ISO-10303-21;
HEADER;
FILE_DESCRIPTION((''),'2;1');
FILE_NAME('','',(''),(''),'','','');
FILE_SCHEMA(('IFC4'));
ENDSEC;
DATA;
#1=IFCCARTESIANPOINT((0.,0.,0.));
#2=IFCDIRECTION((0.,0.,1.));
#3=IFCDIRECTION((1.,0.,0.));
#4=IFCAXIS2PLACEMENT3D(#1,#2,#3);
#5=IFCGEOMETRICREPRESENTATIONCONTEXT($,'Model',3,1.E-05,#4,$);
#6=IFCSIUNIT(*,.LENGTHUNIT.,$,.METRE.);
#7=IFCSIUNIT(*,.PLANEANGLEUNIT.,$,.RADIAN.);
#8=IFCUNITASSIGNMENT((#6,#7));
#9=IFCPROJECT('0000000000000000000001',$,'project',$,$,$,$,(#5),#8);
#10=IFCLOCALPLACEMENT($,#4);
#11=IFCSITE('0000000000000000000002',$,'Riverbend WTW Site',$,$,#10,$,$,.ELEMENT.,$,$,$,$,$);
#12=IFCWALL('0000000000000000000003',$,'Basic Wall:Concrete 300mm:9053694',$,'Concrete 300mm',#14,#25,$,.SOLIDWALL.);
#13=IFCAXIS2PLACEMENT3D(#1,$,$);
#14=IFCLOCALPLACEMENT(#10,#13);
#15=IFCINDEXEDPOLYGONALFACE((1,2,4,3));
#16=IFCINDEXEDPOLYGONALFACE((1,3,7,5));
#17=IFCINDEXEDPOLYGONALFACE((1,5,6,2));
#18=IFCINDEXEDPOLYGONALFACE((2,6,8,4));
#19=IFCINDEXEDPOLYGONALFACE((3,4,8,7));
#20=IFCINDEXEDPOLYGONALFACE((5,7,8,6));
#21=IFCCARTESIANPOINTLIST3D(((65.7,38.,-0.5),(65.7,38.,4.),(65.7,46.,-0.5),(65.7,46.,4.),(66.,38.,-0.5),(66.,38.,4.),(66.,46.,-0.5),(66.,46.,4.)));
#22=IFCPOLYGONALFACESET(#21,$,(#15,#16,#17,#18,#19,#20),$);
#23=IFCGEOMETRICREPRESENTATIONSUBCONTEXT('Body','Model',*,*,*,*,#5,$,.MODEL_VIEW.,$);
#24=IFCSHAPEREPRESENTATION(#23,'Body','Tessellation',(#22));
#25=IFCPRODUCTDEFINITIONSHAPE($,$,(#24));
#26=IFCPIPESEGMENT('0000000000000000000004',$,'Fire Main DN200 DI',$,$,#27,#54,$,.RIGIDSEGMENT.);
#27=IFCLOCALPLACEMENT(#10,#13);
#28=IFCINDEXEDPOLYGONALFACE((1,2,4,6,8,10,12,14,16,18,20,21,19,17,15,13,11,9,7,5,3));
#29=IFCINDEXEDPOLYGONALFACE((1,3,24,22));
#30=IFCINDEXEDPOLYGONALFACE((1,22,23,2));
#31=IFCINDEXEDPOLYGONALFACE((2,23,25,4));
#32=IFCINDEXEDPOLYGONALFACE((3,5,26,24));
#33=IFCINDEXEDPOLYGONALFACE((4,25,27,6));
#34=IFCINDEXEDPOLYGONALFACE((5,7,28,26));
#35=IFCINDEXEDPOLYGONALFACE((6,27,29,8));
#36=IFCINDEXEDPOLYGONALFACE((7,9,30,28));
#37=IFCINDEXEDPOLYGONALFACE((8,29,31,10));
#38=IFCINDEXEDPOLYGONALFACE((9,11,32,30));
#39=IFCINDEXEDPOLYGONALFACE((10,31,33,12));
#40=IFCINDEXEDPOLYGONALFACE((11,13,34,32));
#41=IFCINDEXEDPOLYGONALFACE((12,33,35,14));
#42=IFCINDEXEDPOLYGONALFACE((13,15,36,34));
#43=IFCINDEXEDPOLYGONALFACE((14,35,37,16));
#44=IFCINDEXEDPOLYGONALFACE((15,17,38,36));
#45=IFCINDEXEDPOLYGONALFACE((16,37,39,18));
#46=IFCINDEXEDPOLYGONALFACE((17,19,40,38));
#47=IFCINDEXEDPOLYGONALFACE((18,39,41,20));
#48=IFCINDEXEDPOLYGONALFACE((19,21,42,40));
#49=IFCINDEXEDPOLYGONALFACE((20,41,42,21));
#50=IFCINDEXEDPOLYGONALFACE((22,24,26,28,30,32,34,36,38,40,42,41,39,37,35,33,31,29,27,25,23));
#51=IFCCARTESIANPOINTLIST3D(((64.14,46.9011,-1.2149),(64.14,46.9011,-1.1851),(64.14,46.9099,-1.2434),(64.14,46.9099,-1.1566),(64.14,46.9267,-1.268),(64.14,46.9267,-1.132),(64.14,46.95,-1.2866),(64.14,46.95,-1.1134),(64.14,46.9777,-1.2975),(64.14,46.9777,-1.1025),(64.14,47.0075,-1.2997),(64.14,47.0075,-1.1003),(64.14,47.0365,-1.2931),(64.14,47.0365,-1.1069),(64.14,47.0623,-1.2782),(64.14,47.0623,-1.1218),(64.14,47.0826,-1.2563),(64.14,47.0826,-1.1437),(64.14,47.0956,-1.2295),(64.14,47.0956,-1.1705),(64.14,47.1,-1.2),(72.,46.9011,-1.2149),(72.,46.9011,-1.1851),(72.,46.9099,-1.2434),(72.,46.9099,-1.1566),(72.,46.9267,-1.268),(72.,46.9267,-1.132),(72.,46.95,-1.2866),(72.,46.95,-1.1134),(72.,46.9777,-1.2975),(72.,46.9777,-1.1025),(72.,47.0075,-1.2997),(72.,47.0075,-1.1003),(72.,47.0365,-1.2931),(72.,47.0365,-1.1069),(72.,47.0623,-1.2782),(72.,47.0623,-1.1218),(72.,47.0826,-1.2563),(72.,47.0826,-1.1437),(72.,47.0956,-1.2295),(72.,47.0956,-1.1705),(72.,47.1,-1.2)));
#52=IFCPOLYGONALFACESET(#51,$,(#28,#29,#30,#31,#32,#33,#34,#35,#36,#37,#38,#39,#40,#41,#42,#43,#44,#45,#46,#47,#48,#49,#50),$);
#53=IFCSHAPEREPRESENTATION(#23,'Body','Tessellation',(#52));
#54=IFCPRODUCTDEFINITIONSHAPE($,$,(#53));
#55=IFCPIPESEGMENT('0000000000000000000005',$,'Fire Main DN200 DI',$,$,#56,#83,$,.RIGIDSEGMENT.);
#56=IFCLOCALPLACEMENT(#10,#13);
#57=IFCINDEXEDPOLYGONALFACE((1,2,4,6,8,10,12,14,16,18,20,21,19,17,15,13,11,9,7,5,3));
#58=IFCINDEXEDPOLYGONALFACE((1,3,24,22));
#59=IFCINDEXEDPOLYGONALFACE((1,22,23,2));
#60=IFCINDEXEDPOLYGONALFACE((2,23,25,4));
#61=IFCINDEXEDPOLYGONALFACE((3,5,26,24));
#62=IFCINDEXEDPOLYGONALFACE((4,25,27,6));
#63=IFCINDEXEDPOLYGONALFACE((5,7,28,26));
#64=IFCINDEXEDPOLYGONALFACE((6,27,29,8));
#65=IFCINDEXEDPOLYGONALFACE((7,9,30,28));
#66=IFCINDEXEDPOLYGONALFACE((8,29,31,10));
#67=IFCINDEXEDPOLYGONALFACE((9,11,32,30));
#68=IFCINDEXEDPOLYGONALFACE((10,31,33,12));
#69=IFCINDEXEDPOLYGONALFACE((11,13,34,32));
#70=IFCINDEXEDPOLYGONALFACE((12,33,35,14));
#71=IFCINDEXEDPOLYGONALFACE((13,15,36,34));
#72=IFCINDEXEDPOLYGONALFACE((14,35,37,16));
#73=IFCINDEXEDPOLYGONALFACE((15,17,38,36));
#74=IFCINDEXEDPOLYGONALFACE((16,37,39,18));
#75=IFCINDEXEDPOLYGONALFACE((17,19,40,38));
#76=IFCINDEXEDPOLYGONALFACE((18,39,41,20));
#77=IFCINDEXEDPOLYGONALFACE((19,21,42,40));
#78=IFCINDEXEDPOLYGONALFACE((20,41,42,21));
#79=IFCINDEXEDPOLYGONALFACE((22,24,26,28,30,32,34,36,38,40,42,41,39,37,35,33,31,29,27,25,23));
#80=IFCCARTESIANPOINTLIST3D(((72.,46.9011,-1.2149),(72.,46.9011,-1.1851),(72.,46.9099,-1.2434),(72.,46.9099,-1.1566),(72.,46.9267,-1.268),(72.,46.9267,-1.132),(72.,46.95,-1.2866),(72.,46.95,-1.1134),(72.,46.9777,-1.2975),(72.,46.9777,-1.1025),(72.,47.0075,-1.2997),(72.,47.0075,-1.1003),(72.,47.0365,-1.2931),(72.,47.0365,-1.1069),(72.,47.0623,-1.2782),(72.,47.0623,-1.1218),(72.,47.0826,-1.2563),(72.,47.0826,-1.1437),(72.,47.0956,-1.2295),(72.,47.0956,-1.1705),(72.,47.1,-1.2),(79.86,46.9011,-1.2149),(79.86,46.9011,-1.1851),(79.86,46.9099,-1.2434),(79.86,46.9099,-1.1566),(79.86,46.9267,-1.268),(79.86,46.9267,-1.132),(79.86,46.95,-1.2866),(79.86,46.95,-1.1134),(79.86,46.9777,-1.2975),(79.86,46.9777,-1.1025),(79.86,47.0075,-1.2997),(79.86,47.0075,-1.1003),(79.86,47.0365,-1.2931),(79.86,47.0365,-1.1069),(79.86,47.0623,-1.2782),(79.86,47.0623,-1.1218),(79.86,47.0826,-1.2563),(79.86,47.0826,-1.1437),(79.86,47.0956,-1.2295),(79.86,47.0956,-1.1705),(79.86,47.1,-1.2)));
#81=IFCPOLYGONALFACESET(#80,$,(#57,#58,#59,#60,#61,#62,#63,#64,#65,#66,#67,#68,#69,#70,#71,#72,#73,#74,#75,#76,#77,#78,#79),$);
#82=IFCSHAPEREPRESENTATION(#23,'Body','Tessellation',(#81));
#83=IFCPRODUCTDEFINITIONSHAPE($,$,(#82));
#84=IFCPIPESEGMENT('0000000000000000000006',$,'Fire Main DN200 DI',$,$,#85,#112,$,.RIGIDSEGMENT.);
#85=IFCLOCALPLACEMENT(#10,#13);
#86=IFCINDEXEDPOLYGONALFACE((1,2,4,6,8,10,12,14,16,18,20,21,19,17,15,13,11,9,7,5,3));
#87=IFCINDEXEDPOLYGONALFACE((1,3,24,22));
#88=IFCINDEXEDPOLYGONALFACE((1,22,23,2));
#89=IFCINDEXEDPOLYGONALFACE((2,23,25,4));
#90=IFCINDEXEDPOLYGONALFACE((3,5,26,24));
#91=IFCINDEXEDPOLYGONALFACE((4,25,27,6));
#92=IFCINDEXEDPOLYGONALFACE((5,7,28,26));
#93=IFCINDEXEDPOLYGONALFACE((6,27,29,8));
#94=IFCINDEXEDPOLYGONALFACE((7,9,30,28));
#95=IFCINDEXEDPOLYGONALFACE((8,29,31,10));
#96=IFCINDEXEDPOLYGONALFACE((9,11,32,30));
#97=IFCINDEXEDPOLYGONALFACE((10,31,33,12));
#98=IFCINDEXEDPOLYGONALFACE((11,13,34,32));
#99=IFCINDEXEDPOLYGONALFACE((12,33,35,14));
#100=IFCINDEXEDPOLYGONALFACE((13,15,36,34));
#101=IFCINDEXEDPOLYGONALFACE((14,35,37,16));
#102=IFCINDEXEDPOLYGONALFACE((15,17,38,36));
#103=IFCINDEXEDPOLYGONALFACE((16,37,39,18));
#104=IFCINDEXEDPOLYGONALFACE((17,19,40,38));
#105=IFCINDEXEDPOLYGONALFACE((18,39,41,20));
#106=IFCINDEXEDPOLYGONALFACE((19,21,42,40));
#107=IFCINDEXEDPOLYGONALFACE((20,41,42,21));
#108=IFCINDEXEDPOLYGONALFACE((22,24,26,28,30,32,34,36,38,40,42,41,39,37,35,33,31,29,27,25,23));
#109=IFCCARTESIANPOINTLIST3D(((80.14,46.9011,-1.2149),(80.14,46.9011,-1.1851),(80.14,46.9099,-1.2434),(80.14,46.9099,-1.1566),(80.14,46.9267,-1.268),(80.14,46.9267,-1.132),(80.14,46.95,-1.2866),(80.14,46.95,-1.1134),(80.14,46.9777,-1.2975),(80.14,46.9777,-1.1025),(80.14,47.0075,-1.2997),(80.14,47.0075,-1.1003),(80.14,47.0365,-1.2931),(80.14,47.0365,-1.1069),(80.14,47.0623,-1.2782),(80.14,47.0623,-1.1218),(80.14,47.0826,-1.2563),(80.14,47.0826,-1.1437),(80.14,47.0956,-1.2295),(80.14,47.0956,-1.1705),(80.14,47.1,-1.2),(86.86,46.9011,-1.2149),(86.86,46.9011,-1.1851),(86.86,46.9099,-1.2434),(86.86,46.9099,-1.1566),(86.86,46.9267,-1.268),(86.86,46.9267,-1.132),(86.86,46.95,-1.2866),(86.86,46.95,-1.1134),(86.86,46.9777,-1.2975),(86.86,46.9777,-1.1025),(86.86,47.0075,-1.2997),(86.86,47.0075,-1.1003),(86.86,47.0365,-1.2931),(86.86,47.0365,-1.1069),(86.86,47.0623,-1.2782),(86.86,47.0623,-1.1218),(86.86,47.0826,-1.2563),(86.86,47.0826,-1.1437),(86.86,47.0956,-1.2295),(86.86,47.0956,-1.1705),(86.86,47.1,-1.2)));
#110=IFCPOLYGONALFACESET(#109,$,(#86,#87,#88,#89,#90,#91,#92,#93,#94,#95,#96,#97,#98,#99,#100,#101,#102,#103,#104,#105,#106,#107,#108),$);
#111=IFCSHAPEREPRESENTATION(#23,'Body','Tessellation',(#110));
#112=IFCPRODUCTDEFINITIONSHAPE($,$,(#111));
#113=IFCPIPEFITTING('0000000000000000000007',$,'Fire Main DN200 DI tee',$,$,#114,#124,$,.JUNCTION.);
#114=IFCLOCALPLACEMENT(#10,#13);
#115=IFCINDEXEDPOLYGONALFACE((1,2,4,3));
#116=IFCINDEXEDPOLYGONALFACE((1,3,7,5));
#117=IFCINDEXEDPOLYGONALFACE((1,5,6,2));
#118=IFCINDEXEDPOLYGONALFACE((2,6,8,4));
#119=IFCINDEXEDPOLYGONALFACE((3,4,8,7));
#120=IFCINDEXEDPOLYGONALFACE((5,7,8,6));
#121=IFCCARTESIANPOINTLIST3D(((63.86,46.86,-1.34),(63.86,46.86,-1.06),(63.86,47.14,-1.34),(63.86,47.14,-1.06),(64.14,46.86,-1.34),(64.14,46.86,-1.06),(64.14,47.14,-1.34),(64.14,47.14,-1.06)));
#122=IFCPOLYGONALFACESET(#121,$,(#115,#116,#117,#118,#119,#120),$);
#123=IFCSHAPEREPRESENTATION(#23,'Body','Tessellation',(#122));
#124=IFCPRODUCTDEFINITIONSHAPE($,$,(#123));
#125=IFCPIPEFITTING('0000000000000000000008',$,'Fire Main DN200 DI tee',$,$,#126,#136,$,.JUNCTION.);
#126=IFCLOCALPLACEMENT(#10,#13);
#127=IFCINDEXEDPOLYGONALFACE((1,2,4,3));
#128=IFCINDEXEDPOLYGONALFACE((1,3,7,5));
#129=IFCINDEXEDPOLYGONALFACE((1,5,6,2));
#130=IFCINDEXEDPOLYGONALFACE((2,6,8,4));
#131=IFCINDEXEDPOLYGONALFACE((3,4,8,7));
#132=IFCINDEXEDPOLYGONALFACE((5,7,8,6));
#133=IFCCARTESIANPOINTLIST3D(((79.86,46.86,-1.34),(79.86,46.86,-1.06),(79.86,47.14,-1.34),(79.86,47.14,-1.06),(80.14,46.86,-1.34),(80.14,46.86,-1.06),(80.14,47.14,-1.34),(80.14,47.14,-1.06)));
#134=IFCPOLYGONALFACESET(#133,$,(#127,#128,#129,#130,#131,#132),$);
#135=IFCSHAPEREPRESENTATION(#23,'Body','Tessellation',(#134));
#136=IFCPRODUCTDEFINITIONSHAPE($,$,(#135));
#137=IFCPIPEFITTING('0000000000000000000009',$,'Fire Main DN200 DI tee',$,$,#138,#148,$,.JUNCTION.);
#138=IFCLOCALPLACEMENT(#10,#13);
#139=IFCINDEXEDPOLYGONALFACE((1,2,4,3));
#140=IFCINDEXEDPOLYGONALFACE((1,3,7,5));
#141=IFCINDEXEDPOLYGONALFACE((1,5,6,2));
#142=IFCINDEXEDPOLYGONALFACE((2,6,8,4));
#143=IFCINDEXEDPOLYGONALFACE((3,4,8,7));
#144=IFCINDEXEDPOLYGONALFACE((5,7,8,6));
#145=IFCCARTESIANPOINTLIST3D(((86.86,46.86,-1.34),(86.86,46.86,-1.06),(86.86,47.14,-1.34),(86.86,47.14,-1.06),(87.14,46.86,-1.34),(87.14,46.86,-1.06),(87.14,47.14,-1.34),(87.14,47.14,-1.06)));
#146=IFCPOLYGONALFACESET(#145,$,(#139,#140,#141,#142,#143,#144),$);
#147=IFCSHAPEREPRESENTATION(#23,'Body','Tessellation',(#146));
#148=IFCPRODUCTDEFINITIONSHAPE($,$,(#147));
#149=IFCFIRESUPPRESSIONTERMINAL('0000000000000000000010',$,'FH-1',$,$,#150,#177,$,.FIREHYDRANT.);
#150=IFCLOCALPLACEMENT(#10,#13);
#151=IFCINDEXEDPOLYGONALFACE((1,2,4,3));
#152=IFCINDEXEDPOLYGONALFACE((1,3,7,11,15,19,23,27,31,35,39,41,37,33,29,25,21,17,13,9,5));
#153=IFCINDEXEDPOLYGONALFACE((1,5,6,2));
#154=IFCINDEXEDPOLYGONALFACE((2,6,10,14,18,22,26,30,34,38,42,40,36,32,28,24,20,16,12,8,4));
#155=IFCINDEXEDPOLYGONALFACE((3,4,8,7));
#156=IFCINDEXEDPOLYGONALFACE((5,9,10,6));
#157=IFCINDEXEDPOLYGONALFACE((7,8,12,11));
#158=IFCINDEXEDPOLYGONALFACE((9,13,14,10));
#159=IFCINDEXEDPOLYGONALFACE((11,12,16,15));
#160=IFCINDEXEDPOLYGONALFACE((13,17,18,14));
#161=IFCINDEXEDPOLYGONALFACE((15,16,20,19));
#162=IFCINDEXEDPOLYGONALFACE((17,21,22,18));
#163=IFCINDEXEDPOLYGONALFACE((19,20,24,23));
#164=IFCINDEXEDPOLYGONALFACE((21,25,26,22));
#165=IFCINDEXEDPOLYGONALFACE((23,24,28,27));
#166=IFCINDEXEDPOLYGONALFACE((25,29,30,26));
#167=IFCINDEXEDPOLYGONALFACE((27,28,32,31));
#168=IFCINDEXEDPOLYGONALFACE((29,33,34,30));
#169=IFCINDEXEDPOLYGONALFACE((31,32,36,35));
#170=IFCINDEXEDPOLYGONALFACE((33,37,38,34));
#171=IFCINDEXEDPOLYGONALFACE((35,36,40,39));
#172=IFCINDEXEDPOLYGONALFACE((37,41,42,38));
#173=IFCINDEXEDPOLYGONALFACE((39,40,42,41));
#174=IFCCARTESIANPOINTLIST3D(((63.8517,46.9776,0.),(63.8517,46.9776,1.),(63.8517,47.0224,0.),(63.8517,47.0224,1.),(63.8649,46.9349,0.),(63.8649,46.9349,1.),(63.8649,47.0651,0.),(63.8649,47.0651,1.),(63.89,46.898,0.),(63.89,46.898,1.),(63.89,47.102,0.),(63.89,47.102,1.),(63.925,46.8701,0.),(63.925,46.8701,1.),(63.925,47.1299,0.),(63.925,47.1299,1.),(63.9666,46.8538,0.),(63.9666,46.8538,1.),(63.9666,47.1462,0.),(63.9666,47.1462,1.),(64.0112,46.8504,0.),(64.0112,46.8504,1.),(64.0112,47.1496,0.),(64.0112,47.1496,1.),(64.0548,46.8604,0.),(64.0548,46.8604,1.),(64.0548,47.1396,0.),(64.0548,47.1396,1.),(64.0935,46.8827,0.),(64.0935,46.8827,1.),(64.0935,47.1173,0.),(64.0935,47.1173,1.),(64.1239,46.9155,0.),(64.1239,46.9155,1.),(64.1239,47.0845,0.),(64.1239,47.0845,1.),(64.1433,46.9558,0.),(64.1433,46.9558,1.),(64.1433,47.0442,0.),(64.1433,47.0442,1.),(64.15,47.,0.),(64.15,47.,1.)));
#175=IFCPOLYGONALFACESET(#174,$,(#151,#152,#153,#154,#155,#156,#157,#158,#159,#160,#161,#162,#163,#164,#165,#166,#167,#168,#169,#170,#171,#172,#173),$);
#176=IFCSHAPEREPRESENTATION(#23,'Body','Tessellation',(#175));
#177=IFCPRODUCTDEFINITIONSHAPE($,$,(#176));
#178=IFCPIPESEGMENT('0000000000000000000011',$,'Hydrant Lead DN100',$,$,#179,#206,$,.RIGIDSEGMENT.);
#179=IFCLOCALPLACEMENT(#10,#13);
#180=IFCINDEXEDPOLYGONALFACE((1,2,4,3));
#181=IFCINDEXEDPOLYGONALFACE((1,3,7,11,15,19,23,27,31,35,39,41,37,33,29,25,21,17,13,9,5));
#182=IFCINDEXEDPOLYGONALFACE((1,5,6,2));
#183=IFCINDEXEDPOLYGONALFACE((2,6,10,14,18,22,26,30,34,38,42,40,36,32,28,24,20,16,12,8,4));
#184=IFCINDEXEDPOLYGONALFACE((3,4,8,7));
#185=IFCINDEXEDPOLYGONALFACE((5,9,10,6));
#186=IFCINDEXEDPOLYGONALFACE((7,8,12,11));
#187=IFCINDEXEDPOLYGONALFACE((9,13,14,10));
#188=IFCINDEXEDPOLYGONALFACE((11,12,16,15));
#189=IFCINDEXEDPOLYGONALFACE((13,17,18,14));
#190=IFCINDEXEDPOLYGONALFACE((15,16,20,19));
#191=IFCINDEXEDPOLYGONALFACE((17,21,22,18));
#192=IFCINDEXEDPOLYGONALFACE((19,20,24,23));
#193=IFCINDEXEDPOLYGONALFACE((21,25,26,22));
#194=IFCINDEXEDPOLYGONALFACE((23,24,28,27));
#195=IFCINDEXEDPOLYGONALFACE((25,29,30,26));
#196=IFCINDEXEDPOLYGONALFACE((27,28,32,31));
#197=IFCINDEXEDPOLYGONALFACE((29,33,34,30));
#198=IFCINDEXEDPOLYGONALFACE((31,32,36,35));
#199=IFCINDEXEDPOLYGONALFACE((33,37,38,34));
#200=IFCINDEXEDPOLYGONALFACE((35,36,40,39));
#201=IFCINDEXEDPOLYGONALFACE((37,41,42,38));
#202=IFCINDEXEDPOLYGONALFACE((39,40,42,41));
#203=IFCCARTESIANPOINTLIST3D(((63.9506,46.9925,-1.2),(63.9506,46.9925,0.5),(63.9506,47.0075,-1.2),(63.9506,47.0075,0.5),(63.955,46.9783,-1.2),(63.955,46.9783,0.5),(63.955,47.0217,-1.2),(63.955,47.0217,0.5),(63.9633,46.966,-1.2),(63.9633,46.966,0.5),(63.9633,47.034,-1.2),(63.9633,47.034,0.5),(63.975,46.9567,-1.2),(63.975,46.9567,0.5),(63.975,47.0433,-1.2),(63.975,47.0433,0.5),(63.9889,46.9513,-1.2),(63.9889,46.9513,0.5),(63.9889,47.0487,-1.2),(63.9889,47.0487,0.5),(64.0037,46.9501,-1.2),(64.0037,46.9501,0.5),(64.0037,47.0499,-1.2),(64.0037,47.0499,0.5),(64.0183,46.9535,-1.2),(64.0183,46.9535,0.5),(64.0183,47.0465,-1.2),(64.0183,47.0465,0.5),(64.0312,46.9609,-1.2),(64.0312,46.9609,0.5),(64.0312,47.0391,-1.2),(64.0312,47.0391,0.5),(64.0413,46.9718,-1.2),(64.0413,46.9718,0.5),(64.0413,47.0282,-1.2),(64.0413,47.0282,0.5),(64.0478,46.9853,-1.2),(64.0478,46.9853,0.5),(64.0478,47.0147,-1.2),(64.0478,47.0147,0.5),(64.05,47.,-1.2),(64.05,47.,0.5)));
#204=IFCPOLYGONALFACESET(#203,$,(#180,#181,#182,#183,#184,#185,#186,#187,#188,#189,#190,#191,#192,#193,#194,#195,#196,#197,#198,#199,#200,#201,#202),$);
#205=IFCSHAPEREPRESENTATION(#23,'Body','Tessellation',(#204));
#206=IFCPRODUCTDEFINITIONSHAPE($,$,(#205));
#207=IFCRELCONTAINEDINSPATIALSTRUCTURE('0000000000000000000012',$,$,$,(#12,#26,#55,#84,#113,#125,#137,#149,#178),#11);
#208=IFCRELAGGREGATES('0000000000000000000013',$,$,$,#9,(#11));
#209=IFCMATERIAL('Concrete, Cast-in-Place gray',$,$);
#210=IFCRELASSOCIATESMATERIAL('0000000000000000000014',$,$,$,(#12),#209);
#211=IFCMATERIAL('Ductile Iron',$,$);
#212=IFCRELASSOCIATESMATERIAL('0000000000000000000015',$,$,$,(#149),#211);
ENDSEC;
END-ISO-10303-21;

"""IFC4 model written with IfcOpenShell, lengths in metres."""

from ifc_helpers import new_model, si_unit, frame, origin_with_axes, origin_2d, place, context, subcontext, project, spatial, rectangle, circle, extrude, material, element, save


model = new_model("IFC4")

# Units and contexts
model_context = context("Model", 3, precision=1e-05, world=origin_with_axes())
body_context = subcontext(model_context, "Body", "Model", "MODEL_VIEW")
ifc_project = project(units=[si_unit("LENGTHUNIT", "METRE"), si_unit("PLANEANGLEUNIT", "RADIAN")], contexts=[model_context])

# Site
site_placement = place(None, origin_with_axes())
site = spatial("IfcSite", under=ifc_project, at=site_placement, Name="Riverbend WTW Site", CompositionType="ELEMENT")

# Wall
ifc_material_1 = material(Name="Concrete, Cast-in-Place gray")
wall_placement = place(None, frame((65.85, 42.0, 1.75), z_axis=(0.0, 0.0, 1.0), x_axis=(1.0, 0.0, 0.0)))
element("IfcWall", 1, at=wall_placement, inside=site, material=ifc_material_1, Name="Basic Wall:Concrete 300mm:9053694", ObjectType="Concrete 300mm", PredefinedType="SOLIDWALL", context=body_context, shape_type="SweptSolid", body=[
    extrude(rectangle(XDim=0.3, YDim=8.0, at=origin_2d()), frame((0.0, 0.0, -2.25), z_axis=(0.0, 0.0, 1.0), x_axis=(1.0, 0.0, 0.0)), (0.0, 0.0, 1.0), 4.5),
])

# Pipe segments
for number, where, z_axis, x_axis, name in (
    (2, (64.14, 47.0, -1.2), (0.0, 0.0, 1.0), (1.0, 0.0, 0.0), "Fire Main DN200 DI"),
    (3, (72.0, 47.0, -1.2), (0.0, 0.0, 1.0), (1.0, 0.0, 0.0), "Fire Main DN200 DI"),
):
    element("IfcPipeSegment", number, at=place(None, frame(where, z_axis=z_axis, x_axis=x_axis)), inside=site, Name=name, PredefinedType="RIGIDSEGMENT", context=body_context, shape_type="SweptSolid", body=[
        extrude(circle(Radius=0.1, at=origin_2d()), frame((0.0, 0.0, 0.0), z_axis=(1.0, 0.0, 0.0), x_axis=(0.0, 1.0, 0.0)), (0.0, 0.0, 1.0), 7.86),
    ])
pipe_segment_1_placement = place(None, frame((80.14, 47.0, -1.2), z_axis=(0.0, 0.0, 1.0), x_axis=(1.0, 0.0, 0.0)))
element("IfcPipeSegment", 4, at=pipe_segment_1_placement, inside=site, Name="Fire Main DN200 DI", PredefinedType="RIGIDSEGMENT", context=body_context, shape_type="SweptSolid", body=[
    extrude(circle(Radius=0.1, at=origin_2d()), frame((0.0, 0.0, 0.0), z_axis=(1.0, 0.0, 0.0), x_axis=(0.0, 1.0, 0.0)), (0.0, 0.0, 1.0), 6.72),
])

# Pipe fittings
for number, where, z_axis, x_axis, name in (
    (5, (64.0, 47.0, -1.2), (0.0, 0.0, 1.0), (1.0, 0.0, 0.0), "Fire Main DN200 DI tee"),
    (6, (80.0, 47.0, -1.2), (0.0, 0.0, 1.0), (1.0, 0.0, 0.0), "Fire Main DN200 DI tee"),
    (7, (87.0, 47.0, -1.2), (0.0, 0.0, 1.0), (1.0, 0.0, 0.0), "Fire Main DN200 DI tee"),
):
    element("IfcPipeFitting", number, at=place(None, frame(where, z_axis=z_axis, x_axis=x_axis)), inside=site, Name=name, PredefinedType="JUNCTION", context=body_context, shape_type="SweptSolid", body=[
        extrude(rectangle(XDim=0.28, YDim=0.28, at=origin_2d()), frame((0.0, 0.0, -0.14), z_axis=(0.0, 0.0, 1.0), x_axis=(1.0, 0.0, 0.0)), (0.0, 0.0, 1.0), 0.28),
    ])

# Fire suppression terminal
ifc_material_2 = material(Name="Ductile Iron")
fire_suppression_terminal_1_placement = place(None, frame((64.0, 47.0, 0.0), z_axis=(0.0, 0.0, 1.0), x_axis=(1.0, 0.0, 0.0)))
element("IfcFireSuppressionTerminal", 8, at=fire_suppression_terminal_1_placement, inside=site, material=ifc_material_2, Name="FH-1", PredefinedType="FIREHYDRANT", context=body_context, shape_type="SweptSolid", body=[
    extrude(circle(Radius=0.15, at=origin_2d()), origin_with_axes(), (0.0, 0.0, 1.0), 1.0),
])

# Pipe segment
pipe_segment_2_placement = place(None, frame((64.0, 47.0, -1.2), z_axis=(0.0, 0.0, 1.0), x_axis=(1.0, 0.0, 0.0)))
element("IfcPipeSegment", 9, at=pipe_segment_2_placement, inside=site, Name="Hydrant Lead DN100", PredefinedType="RIGIDSEGMENT", context=body_context, shape_type="SweptSolid", body=[
    extrude(circle(Radius=0.05, at=origin_2d()), origin_with_axes(), (0.0, 0.0, 1.0), 1.7),
])

save(model, "model.ifc")
